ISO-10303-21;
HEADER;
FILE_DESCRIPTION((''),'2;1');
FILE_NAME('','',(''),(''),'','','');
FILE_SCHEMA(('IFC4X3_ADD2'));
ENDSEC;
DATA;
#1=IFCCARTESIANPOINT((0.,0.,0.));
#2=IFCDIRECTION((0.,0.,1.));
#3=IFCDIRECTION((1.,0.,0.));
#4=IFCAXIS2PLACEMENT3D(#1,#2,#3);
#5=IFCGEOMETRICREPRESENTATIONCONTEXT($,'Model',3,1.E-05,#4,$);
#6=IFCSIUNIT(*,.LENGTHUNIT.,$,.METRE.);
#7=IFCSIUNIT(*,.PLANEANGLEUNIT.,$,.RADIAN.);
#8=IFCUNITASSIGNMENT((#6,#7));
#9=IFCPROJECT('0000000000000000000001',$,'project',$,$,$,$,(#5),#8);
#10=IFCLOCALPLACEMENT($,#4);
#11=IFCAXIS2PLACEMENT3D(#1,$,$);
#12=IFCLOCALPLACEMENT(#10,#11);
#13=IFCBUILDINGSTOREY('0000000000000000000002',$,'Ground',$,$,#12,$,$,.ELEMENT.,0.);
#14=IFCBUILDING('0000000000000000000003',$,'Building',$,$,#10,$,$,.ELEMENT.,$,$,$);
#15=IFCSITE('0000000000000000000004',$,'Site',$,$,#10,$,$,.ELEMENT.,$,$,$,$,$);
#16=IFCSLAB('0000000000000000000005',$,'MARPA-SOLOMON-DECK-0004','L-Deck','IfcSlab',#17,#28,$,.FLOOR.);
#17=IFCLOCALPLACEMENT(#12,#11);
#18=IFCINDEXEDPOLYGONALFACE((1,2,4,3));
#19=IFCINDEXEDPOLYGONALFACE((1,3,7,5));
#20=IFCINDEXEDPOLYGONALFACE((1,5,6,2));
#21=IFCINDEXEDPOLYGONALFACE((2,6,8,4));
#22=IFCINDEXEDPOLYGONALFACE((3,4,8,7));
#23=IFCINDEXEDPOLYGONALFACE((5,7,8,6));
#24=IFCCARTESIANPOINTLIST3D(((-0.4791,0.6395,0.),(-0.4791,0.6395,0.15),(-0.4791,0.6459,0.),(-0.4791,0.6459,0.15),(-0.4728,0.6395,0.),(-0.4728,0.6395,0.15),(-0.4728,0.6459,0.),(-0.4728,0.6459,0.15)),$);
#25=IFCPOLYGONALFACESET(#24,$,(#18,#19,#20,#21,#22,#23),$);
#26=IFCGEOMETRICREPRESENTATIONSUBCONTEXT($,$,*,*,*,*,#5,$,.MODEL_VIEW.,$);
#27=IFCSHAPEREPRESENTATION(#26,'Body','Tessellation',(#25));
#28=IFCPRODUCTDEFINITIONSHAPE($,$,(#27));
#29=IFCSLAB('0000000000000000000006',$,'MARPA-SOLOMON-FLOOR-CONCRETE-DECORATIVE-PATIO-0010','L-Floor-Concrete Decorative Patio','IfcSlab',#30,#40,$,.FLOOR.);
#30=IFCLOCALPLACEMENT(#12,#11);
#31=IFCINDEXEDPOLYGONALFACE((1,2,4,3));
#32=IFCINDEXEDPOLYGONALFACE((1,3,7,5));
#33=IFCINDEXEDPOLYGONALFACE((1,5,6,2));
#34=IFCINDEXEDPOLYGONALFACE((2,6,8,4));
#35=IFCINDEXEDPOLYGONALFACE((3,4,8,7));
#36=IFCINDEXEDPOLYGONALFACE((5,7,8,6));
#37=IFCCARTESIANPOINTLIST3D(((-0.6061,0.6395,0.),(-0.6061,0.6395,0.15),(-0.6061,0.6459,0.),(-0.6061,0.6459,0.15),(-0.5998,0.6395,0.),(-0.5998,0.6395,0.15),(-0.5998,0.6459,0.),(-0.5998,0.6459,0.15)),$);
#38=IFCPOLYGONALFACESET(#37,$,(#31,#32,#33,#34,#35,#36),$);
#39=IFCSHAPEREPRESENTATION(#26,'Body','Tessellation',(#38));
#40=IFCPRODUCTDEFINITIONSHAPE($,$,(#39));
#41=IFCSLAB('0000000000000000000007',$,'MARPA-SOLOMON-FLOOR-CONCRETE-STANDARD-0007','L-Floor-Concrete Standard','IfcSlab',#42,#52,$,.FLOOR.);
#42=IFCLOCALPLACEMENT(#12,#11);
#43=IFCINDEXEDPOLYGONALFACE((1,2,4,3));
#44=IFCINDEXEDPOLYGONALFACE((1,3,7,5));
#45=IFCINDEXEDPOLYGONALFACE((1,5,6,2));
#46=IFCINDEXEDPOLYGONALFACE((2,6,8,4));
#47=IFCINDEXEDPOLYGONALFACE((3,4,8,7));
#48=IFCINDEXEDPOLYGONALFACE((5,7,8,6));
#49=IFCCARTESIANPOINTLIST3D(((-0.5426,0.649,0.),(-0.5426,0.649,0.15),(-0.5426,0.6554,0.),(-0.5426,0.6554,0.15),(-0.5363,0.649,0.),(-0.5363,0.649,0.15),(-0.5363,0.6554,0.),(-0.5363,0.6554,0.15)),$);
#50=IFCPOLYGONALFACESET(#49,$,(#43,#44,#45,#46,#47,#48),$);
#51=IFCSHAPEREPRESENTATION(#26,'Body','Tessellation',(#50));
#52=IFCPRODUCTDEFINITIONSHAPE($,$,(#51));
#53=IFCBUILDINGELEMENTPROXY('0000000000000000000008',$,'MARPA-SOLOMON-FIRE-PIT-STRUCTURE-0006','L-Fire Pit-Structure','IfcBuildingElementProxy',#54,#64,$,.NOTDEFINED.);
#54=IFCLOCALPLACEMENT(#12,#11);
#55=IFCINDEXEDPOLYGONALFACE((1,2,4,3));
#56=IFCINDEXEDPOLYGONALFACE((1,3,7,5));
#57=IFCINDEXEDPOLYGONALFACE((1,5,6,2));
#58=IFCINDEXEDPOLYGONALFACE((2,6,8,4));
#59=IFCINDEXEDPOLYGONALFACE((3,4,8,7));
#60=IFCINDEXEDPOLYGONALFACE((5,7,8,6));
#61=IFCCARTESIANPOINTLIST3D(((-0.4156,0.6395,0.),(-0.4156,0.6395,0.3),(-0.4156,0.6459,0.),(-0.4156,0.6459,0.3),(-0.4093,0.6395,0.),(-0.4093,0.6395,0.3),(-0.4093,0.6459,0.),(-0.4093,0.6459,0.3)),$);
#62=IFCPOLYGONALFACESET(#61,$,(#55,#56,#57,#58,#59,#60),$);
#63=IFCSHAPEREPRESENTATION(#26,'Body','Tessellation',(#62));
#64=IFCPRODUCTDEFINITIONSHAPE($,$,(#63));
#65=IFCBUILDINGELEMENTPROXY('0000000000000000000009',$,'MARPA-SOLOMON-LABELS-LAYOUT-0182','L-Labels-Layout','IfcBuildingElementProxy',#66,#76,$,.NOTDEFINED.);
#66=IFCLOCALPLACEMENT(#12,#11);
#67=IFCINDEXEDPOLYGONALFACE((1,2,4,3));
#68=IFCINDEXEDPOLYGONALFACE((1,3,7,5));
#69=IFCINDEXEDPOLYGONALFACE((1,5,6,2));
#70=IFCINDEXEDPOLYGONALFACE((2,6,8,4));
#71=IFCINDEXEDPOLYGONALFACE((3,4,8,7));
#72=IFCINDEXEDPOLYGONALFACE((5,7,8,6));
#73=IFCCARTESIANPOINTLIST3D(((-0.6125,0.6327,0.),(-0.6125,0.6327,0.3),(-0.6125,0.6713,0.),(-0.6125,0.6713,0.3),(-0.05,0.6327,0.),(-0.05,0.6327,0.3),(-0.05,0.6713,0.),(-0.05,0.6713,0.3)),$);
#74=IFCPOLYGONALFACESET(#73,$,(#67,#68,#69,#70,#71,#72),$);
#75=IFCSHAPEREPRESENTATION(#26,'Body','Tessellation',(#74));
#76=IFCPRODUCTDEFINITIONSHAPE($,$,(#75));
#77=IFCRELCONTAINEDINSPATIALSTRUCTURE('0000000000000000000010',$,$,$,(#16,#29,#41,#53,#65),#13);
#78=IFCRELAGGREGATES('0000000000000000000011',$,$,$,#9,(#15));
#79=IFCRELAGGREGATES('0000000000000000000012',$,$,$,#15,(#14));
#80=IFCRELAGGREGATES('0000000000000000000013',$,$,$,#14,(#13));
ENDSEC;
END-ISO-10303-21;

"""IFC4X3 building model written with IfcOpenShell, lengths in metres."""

from ifc_helpers import new_model, si_unit, frame, origin, origin_with_axes, place, context, subcontext, project, spatial, polyline, outline, extrude, element, save


model = new_model("IFC4X3")

# Units and contexts
model_context = context("Model", 3, precision=1e-05, world=origin_with_axes())
sub_context = subcontext(model_context, None, None, "MODEL_VIEW")
ifc_project = project(units=[si_unit("LENGTHUNIT", "METRE"), si_unit("PLANEANGLEUNIT", "RADIAN")], contexts=[model_context])

# Site, building, storey
placement = place(None, origin_with_axes())
site = spatial("IfcSite", under=ifc_project, at=placement, Name="Site", CompositionType="ELEMENT")
building = spatial("IfcBuilding", under=site, at=placement, Name="Building", CompositionType="ELEMENT")
storey_placement = place(placement, origin())
storey = spatial("IfcBuildingStorey", under=building, at=storey_placement, Name="Ground", CompositionType="ELEMENT", Elevation=0.0)

# Slabs
for number, where, name in (
    (1, (-0.4791, 0.6395, 0.0), "MARPA-SOLOMON-DECK-0004"),
):
    element("IfcSlab", number, at=place(storey_placement, frame(where)), inside=storey, Name=name, Description="L-Deck", ObjectType="IfcSlab", PredefinedType="FLOOR", context=sub_context, shape_type="SweptSolid", body=[
        extrude(outline(polyline([(0.0, 0.0063), (0.0063, 0.0063), (0.0063, 0.0), (0.0, 0.0), (0.0, 0.0063)])), origin(), (0.0, 0.0, 1.0), 0.15),
    ])
for number, where, name, description in (
    (2, (-0.6061, 0.6395, 0.0), "MARPA-SOLOMON-FLOOR-CONCRETE-DECORATIVE-PATIO-0010", "L-Floor-Concrete Decorative Patio"),
    (3, (-0.5426, 0.649, 0.0), "MARPA-SOLOMON-FLOOR-CONCRETE-STANDARD-0007", "L-Floor-Concrete Standard"),
):
    element("IfcSlab", number, at=place(storey_placement, frame(where)), inside=storey, Name=name, Description=description, ObjectType="IfcSlab", PredefinedType="FLOOR", context=sub_context, shape_type="SweptSolid", body=[
        extrude(outline(polyline([(0.0, 0.0063), (0.0063, 0.0063), (0.0063, 0.0), (0.0, 0.0), (0.0, 0.0063)])), origin(), (0.0, 0.0, 1.0), 0.15),
    ])

# Building element proxies
for number, where, name in (
    (4, (-0.4156, 0.6395, 0.0), "MARPA-SOLOMON-FIRE-PIT-STRUCTURE-0006"),
):
    element("IfcBuildingElementProxy", number, at=place(placement, frame(where)), inside=storey, Name=name, Description="L-Fire Pit-Structure", ObjectType="IfcBuildingElementProxy", PredefinedType="NOTDEFINED", context=sub_context, shape_type="SweptSolid", body=[
        extrude(outline(polyline([(0.0, 0.0063), (0.0063, 0.0063), (0.0063, 0.0), (0.0, 0.0), (0.0, 0.0063)])), origin(), (0.0, 0.0, 1.0), 0.3),
    ])
proxy_placement = place(placement, frame((-0.6125, 0.6327, 0.0)))
element("IfcBuildingElementProxy", 5, at=proxy_placement, inside=storey, Name="MARPA-SOLOMON-LABELS-LAYOUT-0182", Description="L-Labels-Layout", ObjectType="IfcBuildingElementProxy", PredefinedType="NOTDEFINED", context=sub_context, shape_type="SweptSolid", body=[
    extrude(outline(polyline([(0.0, 0.0385), (0.5625, 0.0385), (0.5625, 0.0), (0.0, 0.0), (0.0, 0.0385)])), origin(), (0.0, 0.0, 1.0), 0.3),
])

save(model, "model.ifc")
